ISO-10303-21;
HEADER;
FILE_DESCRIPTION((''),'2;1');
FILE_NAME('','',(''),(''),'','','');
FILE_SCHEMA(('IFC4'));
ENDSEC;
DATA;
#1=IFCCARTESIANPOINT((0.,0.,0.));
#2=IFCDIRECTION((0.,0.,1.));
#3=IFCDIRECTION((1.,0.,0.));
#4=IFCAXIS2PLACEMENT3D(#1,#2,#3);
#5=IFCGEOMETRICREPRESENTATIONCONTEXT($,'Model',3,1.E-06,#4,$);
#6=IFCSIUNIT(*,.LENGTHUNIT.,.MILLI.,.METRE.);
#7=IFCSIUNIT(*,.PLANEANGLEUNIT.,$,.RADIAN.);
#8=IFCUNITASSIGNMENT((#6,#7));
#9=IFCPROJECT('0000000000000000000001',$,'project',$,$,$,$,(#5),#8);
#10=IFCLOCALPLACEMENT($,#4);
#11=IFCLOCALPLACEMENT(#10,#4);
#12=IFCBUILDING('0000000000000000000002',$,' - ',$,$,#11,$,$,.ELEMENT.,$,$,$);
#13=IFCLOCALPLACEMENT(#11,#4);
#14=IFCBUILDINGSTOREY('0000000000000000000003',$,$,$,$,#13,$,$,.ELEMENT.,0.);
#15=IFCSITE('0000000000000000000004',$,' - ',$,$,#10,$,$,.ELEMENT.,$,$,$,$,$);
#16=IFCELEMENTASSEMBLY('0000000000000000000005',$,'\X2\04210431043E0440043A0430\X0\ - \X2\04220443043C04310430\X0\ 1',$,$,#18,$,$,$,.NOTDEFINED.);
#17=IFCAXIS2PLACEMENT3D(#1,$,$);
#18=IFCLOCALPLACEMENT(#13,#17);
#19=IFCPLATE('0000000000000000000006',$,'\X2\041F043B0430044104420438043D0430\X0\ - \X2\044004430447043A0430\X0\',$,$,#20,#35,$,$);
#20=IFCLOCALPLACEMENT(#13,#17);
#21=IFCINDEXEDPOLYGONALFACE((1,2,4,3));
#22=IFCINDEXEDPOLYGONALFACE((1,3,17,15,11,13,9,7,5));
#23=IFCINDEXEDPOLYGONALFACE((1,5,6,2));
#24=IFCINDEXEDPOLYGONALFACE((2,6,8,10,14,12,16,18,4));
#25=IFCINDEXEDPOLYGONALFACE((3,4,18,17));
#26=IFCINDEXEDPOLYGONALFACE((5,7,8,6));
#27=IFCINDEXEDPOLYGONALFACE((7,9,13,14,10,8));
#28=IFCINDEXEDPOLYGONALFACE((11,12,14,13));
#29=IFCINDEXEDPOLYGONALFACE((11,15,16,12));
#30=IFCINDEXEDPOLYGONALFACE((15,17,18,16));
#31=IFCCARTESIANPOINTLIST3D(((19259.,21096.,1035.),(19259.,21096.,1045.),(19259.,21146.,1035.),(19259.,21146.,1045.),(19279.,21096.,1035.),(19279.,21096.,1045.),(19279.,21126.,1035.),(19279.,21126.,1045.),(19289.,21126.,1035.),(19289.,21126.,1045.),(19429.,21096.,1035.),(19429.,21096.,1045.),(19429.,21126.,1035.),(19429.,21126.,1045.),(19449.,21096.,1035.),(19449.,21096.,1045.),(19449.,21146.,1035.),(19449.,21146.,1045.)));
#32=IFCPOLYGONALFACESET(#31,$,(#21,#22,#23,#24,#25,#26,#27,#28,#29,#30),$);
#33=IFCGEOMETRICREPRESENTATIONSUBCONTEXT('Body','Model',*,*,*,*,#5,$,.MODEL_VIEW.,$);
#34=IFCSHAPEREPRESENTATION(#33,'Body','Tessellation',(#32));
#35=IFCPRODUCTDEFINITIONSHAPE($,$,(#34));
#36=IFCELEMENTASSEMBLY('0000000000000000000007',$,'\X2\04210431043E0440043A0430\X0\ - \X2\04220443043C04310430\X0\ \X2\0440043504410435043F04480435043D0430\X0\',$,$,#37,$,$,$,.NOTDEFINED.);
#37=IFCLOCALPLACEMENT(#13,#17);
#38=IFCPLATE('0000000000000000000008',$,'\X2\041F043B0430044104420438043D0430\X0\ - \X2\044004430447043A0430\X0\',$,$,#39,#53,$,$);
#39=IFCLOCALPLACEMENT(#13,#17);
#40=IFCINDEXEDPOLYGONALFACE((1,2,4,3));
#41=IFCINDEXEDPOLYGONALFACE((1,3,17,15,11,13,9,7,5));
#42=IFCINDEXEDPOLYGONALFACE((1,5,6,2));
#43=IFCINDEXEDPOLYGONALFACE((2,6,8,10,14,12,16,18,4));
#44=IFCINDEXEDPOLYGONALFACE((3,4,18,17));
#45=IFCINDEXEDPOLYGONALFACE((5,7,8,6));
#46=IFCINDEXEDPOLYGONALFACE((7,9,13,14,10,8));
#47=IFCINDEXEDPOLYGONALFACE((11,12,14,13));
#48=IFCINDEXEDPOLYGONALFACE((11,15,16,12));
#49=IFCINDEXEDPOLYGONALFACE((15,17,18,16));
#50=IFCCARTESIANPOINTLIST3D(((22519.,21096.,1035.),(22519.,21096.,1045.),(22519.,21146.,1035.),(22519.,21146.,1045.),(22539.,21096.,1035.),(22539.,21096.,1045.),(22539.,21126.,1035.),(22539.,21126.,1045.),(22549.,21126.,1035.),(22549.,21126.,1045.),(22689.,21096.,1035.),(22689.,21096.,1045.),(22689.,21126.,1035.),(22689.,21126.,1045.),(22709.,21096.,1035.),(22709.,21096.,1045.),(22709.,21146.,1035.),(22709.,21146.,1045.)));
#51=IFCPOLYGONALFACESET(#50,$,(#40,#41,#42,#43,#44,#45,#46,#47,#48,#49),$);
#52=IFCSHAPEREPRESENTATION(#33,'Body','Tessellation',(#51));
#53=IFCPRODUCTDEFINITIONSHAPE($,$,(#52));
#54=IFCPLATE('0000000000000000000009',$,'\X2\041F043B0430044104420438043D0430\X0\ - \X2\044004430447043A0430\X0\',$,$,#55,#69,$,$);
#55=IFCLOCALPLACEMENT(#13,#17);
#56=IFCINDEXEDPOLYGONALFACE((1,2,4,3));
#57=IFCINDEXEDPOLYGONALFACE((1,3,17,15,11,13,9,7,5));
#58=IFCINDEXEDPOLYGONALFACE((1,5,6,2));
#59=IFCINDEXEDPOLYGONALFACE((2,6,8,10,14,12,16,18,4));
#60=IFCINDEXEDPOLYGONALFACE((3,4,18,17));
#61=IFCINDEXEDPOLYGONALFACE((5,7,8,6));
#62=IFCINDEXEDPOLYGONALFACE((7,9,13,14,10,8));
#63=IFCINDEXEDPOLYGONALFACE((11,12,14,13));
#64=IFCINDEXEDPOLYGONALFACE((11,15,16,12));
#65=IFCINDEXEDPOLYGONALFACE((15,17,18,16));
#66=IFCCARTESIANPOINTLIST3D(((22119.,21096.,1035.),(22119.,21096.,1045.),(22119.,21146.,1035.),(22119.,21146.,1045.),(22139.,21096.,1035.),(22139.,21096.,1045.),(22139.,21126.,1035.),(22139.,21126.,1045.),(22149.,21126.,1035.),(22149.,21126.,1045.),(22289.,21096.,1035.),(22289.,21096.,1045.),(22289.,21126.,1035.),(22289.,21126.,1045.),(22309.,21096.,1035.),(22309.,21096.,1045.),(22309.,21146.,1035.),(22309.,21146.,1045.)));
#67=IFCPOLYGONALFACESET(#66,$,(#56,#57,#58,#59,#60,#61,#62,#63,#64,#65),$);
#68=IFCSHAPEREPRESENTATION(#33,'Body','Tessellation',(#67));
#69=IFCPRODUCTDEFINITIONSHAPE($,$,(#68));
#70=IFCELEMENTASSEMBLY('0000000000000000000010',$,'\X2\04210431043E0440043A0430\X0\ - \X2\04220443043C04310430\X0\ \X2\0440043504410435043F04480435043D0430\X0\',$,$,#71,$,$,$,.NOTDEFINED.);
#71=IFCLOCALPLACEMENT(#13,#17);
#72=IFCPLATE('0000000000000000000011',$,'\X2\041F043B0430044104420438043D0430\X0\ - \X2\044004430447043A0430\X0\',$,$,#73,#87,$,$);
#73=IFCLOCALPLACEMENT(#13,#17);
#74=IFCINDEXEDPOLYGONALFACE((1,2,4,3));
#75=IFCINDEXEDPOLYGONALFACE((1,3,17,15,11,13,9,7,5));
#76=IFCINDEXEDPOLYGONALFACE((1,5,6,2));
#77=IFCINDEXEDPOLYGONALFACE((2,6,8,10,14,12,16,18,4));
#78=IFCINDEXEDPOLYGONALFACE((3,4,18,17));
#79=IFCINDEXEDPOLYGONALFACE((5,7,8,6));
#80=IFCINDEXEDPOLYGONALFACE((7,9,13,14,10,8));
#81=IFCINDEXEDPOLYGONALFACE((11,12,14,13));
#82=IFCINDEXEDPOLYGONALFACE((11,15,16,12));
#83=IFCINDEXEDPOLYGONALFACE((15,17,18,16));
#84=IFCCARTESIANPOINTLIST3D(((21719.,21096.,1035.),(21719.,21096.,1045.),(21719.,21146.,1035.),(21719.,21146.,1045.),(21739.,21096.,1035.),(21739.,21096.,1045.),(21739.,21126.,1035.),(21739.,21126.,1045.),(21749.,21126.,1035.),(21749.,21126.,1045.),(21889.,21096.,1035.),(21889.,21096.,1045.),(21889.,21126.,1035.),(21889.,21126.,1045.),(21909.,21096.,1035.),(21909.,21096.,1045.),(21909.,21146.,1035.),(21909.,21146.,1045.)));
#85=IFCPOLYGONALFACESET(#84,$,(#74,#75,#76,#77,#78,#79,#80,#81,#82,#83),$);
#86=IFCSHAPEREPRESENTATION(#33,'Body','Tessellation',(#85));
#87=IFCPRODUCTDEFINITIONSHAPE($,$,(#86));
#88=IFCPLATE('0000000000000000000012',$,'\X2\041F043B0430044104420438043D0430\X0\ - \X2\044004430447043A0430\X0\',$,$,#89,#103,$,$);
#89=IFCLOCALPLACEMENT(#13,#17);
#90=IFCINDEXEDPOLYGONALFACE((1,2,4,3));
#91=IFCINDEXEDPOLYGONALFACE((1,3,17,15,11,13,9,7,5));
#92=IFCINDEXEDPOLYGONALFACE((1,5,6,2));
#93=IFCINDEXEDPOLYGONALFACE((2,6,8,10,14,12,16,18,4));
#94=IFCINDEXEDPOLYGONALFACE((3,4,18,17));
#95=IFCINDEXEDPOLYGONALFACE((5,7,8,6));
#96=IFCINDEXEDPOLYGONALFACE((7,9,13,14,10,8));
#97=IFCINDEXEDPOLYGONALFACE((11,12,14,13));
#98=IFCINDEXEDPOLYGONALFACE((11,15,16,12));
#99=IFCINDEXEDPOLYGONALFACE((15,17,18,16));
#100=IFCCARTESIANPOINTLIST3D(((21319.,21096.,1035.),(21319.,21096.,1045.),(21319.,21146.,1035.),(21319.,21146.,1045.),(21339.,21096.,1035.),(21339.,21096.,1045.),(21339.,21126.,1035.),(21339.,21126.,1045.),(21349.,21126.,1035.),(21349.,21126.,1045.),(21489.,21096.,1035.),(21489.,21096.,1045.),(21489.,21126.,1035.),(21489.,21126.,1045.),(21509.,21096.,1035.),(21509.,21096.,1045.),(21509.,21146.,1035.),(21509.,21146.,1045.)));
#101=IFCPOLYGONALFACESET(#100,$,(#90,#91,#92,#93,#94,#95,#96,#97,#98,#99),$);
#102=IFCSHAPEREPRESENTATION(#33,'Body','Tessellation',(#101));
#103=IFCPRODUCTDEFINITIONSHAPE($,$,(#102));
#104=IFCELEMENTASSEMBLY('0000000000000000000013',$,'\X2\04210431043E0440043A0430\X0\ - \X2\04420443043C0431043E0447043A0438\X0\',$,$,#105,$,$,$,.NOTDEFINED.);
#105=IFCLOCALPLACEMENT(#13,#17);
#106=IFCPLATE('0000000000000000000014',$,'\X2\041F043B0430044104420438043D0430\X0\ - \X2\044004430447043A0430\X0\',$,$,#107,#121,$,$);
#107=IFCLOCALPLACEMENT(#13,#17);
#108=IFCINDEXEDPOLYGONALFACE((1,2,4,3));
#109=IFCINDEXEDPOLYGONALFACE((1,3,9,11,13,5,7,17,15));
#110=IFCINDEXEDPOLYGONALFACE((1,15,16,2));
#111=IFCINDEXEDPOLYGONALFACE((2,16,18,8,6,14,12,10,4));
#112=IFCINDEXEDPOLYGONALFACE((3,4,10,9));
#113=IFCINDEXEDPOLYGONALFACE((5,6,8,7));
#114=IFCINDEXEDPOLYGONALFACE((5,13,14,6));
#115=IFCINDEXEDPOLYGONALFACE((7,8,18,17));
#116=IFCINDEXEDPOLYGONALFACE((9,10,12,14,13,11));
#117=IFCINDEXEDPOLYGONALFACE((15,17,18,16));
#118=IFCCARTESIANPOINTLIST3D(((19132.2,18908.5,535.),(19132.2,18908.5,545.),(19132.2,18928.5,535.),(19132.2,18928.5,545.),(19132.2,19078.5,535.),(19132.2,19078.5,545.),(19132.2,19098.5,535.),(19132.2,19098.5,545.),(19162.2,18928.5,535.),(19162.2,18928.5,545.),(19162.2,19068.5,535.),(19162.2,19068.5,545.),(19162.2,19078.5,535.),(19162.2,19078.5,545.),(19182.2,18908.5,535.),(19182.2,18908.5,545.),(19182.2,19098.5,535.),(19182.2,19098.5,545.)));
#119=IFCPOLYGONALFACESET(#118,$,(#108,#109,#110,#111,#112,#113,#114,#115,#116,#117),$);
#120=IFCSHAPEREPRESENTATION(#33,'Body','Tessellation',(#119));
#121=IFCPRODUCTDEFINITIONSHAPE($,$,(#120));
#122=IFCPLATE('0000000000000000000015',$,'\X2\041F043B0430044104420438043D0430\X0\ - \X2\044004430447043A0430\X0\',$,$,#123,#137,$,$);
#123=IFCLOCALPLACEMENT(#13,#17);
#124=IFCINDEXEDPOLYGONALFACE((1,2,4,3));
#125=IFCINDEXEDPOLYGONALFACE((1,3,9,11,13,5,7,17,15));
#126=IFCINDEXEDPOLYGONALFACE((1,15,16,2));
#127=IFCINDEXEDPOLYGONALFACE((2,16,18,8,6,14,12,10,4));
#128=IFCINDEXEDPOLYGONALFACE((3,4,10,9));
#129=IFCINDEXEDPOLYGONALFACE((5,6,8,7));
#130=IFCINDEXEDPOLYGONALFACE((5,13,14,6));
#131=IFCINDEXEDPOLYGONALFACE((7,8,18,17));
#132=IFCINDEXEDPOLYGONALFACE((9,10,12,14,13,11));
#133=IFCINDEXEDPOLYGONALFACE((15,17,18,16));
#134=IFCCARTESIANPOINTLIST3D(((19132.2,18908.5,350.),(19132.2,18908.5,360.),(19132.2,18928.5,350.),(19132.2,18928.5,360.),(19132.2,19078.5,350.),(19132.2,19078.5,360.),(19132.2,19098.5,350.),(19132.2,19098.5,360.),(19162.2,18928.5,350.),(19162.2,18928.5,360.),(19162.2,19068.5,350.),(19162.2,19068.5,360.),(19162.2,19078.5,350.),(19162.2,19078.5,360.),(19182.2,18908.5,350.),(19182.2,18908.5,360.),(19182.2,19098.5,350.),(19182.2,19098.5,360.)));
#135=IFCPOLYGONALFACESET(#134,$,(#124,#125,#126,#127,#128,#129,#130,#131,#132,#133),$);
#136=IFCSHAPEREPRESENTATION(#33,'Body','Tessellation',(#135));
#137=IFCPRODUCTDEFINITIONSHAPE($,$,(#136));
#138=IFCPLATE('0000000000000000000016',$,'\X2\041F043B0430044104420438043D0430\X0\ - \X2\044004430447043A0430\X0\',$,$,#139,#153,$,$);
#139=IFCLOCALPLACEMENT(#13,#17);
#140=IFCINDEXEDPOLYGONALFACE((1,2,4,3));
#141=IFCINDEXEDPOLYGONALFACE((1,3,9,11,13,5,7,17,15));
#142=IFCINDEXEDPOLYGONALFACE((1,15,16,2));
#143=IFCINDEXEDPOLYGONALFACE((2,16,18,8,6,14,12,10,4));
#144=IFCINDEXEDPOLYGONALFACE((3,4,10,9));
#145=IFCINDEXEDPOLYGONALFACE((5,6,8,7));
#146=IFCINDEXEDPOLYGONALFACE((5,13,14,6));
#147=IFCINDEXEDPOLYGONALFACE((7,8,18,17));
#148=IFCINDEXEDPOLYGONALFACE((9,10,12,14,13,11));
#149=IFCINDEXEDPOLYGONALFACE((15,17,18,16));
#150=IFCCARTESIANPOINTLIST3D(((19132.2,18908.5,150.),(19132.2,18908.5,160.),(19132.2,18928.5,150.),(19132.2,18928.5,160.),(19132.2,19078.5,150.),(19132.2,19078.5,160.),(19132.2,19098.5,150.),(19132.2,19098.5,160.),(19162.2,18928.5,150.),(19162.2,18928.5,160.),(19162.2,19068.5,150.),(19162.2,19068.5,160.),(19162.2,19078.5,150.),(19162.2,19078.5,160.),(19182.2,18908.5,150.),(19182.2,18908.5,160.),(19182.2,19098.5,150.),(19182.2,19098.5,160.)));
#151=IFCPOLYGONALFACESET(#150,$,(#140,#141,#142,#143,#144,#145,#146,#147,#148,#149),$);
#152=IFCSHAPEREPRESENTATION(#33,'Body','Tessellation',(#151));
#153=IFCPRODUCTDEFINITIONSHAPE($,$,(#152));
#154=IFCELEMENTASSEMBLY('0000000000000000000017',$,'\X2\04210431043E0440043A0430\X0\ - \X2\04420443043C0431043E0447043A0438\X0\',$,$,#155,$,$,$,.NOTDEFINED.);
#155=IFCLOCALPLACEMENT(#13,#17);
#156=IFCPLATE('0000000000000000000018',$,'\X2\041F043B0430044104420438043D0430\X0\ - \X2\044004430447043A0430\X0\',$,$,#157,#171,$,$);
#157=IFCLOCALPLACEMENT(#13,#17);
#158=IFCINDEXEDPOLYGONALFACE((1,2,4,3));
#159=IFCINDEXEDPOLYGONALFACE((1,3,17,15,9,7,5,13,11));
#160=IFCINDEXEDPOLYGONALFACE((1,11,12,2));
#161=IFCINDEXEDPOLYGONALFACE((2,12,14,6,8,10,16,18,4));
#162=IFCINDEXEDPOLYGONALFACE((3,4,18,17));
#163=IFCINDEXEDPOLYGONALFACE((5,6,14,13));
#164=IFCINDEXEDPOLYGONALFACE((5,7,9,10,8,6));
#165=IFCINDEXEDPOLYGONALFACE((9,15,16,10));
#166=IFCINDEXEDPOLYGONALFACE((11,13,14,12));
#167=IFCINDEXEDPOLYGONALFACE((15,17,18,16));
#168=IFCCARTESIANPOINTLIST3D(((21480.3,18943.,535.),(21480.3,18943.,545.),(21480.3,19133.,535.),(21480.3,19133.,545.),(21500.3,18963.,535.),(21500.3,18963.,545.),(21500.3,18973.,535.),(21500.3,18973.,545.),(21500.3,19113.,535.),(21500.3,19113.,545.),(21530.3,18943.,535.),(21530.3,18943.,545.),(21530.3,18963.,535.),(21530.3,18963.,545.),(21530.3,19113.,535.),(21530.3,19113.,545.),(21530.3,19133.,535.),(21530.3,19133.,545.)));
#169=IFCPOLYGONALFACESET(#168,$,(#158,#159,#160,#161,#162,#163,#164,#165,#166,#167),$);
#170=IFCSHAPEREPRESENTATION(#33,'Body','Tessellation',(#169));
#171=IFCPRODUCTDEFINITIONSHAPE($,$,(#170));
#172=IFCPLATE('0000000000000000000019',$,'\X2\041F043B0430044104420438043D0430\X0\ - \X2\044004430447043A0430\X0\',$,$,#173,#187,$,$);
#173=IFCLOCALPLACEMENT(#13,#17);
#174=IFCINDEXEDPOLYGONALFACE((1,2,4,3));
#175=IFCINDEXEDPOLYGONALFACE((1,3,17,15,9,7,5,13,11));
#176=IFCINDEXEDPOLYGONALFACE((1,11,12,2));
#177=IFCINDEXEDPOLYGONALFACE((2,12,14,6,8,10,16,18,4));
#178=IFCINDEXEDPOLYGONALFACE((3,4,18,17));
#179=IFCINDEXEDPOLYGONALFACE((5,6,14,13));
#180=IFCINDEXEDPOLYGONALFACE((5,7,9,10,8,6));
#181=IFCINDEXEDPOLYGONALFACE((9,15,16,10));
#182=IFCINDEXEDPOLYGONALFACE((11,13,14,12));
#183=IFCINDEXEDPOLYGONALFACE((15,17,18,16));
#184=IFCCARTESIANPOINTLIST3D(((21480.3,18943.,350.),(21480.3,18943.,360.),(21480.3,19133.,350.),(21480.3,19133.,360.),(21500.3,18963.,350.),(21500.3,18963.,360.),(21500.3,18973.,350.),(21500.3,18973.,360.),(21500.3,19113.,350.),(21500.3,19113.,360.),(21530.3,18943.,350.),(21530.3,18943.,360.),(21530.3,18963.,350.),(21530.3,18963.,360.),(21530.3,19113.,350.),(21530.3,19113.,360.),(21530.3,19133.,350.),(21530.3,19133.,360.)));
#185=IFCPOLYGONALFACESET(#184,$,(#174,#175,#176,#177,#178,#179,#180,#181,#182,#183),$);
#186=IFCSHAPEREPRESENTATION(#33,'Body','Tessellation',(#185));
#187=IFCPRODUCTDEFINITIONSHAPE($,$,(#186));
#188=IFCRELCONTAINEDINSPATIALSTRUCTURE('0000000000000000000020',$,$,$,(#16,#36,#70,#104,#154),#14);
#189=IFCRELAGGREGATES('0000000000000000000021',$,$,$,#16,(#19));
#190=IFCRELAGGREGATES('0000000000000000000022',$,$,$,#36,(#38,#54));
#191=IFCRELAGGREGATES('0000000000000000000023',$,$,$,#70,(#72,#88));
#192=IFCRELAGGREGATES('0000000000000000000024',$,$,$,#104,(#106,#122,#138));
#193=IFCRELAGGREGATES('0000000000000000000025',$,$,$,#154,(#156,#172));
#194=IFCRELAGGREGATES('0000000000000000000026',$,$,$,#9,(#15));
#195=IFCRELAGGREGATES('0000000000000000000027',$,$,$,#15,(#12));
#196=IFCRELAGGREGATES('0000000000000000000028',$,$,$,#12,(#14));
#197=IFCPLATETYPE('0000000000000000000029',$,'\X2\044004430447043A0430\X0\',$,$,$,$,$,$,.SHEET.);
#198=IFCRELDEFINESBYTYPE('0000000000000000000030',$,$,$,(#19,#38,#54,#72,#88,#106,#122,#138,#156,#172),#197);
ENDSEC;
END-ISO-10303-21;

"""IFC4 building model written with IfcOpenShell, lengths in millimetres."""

from ifc_helpers import new_model, si_unit, frame, origin_with_axes, place, context, subcontext, project, spatial, line, indexed_curve, outline, extrude, source, transform, mapped, type_object, element, aggregate, save


model = new_model("IFC4")

# Units and contexts
model_context = context("Model", 3, precision=1e-06, world=origin_with_axes())
body_context = subcontext(model_context, "Body", "Model", "MODEL_VIEW")
ifc_project = project(units=[si_unit("LENGTHUNIT", "METRE", prefix="MILLI"), si_unit("PLANEANGLEUNIT", "RADIAN")], contexts=[model_context])

# Site, building, storey
site_placement = place(None, origin_with_axes())
site = spatial("IfcSite", under=ifc_project, at=site_placement, Name=" - ", CompositionType="ELEMENT")
building_placement = place(site_placement, origin_with_axes())
building = spatial("IfcBuilding", under=site, at=building_placement, Name=" - ", CompositionType="ELEMENT")
storey_placement = place(building_placement, origin_with_axes())
storey = spatial("IfcBuildingStorey", under=building, at=storey_placement, CompositionType="ELEMENT", Elevation=0.0)

# Element assembly, plate
assembly_1_placement = place(storey_placement, frame((19554.0, 21081.0, 0.0), z_axis=(0.0, 0.0, 1.0), x_axis=(-1.0, 0.0, 0.0)))
assembly_1 = element("IfcElementAssembly", 1, at=assembly_1_placement, inside=storey, Name="Сборка - Тумба 1", PredefinedType="NOTDEFINED")
plate_type = type_object("IfcPlateType", Name="ручка", PredefinedType="SHEET")
shared_shape = source(origin_with_axes(), body_context, "Body", "SweptSolid", [
    extrude(outline(indexed_curve([(-95.0, -25.0), (-75.0, -25.0), (-75.0, 5.0), (-65.0, 5.0), (75.0, 5.0), (75.0, -25.0), (95.0, -25.0), (95.0, 25.0), (-95.0, 25.0)], segments=[line(1, 2), line(2, 3), line(3, 4), line(4, 5), line(5, 6), line(6, 7), line(7, 8), line(8, 9), line(9, 1)])), origin_with_axes(), (0.0, 0.0, 1.0), 10.0),
])
plate_1_placement = place(assembly_1_placement, frame((200.0, -40.0, 1035.0), z_axis=(0.0, 0.0, 1.0), x_axis=(-1.0, 0.0, 0.0)))
plate_1 = element("IfcPlate", 2, at=plate_1_placement, type_object=plate_type, Name="Пластина - ручка", context=body_context, shape_type="MappedRepresentation", body=[
    mapped(shared_shape, transform((0.0, 0.0, 0.0), x_axis=(1.0, 0.0, 0.0), y_axis=(0.0, 1.0, 0.0), z_axis=(0.0, 0.0, 1.0), scale=1.0)),
])
aggregate(assembly_1, [plate_1])

# Element assemblies, plates
assembly_2_placement = place(storey_placement, frame((22814.0, 21081.0, 0.0), z_axis=(0.0, 0.0, 1.0), x_axis=(-1.0, 0.0, 0.0)))
assembly_2 = element("IfcElementAssembly", 3, at=assembly_2_placement, inside=storey, Name="Сборка - Тумба ресепшена", PredefinedType="NOTDEFINED")
plate_2_placement = place(assembly_2_placement, frame((200.0, -40.0, 1035.0), z_axis=(0.0, 0.0, 1.0), x_axis=(-1.0, 0.0, 0.0)))
plate_2 = element("IfcPlate", 4, at=plate_2_placement, type_object=plate_type, Name="Пластина - ручка", context=body_context, shape_type="MappedRepresentation", body=[
    mapped(shared_shape, transform((0.0, 0.0, 0.0), x_axis=(1.0, 0.0, 0.0), y_axis=(0.0, 1.0, 0.0), z_axis=(0.0, 0.0, 1.0), scale=1.0)),
])
plate_3_placement = place(assembly_2_placement, frame((600.0, -40.0, 1035.0), z_axis=(0.0, 0.0, 1.0), x_axis=(-1.0, 0.0, 0.0)))
plate_3 = element("IfcPlate", 5, at=plate_3_placement, type_object=plate_type, Name="Пластина - ручка", context=body_context, shape_type="MappedRepresentation", body=[
    mapped(shared_shape, transform((0.0, 0.0, 0.0), x_axis=(1.0, 0.0, 0.0), y_axis=(0.0, 1.0, 0.0), z_axis=(0.0, 0.0, 1.0), scale=1.0)),
])
aggregate(assembly_2, [plate_2, plate_3])
assembly_3_placement = place(storey_placement, frame((22014.0, 21081.0, 0.0), z_axis=(0.0, 0.0, 1.0), x_axis=(-1.0, 0.0, 0.0)))
assembly_3 = element("IfcElementAssembly", 6, at=assembly_3_placement, inside=storey, Name="Сборка - Тумба ресепшена", PredefinedType="NOTDEFINED")
plate_4_placement = place(assembly_3_placement, frame((200.0, -40.0, 1035.0), z_axis=(0.0, 0.0, 1.0), x_axis=(-1.0, 0.0, 0.0)))
plate_4 = element("IfcPlate", 7, at=plate_4_placement, type_object=plate_type, Name="Пластина - ручка", context=body_context, shape_type="MappedRepresentation", body=[
    mapped(shared_shape, transform((0.0, 0.0, 0.0), x_axis=(1.0, 0.0, 0.0), y_axis=(0.0, 1.0, 0.0), z_axis=(0.0, 0.0, 1.0), scale=1.0)),
])
plate_5_placement = place(assembly_3_placement, frame((600.0, -40.0, 1035.0), z_axis=(0.0, 0.0, 1.0), x_axis=(-1.0, 0.0, 0.0)))
plate_5 = element("IfcPlate", 8, at=plate_5_placement, type_object=plate_type, Name="Пластина - ручка", context=body_context, shape_type="MappedRepresentation", body=[
    mapped(shared_shape, transform((0.0, 0.0, 0.0), x_axis=(1.0, 0.0, 0.0), y_axis=(0.0, 1.0, 0.0), z_axis=(0.0, 0.0, 1.0), scale=1.0)),
])
aggregate(assembly_3, [plate_4, plate_5])
assembly_4_placement = place(storey_placement, frame((19132.2, 18803.5, 0.0), z_axis=(0.0, 0.0, 1.0), x_axis=(0.0, 1.0, 0.0)))
assembly_4 = element("IfcElementAssembly", 9, at=assembly_4_placement, inside=storey, Name="Сборка - тумбочки", PredefinedType="NOTDEFINED")
plate_6_placement = place(assembly_4_placement, frame((200.0, -25.0, 535.0), z_axis=(0.0, 0.0, 1.0), x_axis=(-1.0, 0.0, 0.0)))
plate_6 = element("IfcPlate", 10, at=plate_6_placement, type_object=plate_type, Name="Пластина - ручка", context=body_context, shape_type="MappedRepresentation", body=[
    mapped(shared_shape, transform((0.0, 0.0, 0.0), x_axis=(1.0, 0.0, 0.0), y_axis=(0.0, 1.0, 0.0), z_axis=(0.0, 0.0, 1.0), scale=1.0)),
])
plate_7_placement = place(assembly_4_placement, frame((200.0, -25.0, 350.0), z_axis=(0.0, 0.0, 1.0), x_axis=(-1.0, 0.0, 0.0)))
plate_7 = element("IfcPlate", 11, at=plate_7_placement, type_object=plate_type, Name="Пластина - ручка", context=body_context, shape_type="MappedRepresentation", body=[
    mapped(shared_shape, transform((0.0, 0.0, 0.0), x_axis=(1.0, 0.0, 0.0), y_axis=(0.0, 1.0, 0.0), z_axis=(0.0, 0.0, 1.0), scale=1.0)),
])
plate_8_placement = place(assembly_4_placement, frame((200.0, -25.0, 150.0), z_axis=(0.0, 0.0, 1.0), x_axis=(-1.0, 0.0, 0.0)))
plate_8 = element("IfcPlate", 12, at=plate_8_placement, type_object=plate_type, Name="Пластина - ручка", context=body_context, shape_type="MappedRepresentation", body=[
    mapped(shared_shape, transform((0.0, 0.0, 0.0), x_axis=(1.0, 0.0, 0.0), y_axis=(0.0, 1.0, 0.0), z_axis=(0.0, 0.0, 1.0), scale=1.0)),
])
aggregate(assembly_4, [plate_6, plate_7, plate_8])
assembly_5_placement = place(storey_placement, frame((21530.3, 19238.0, 0.0), z_axis=(0.0, 0.0, 1.0), x_axis=(0.0, -1.0, 0.0)))
assembly_5 = element("IfcElementAssembly", 13, at=assembly_5_placement, inside=storey, Name="Сборка - тумбочки", PredefinedType="NOTDEFINED")
plate_9_placement = place(assembly_5_placement, frame((200.0, -25.0, 535.0), z_axis=(0.0, 0.0, 1.0), x_axis=(-1.0, 0.0, 0.0)))
plate_9 = element("IfcPlate", 14, at=plate_9_placement, type_object=plate_type, Name="Пластина - ручка", context=body_context, shape_type="MappedRepresentation", body=[
    mapped(shared_shape, transform((0.0, 0.0, 0.0), x_axis=(1.0, 0.0, 0.0), y_axis=(0.0, 1.0, 0.0), z_axis=(0.0, 0.0, 1.0), scale=1.0)),
])
plate_10_placement = place(assembly_5_placement, frame((200.0, -25.0, 350.0), z_axis=(0.0, 0.0, 1.0), x_axis=(-1.0, 0.0, 0.0)))
plate_10 = element("IfcPlate", 15, at=plate_10_placement, type_object=plate_type, Name="Пластина - ручка", context=body_context, shape_type="MappedRepresentation", body=[
    mapped(shared_shape, transform((0.0, 0.0, 0.0), x_axis=(1.0, 0.0, 0.0), y_axis=(0.0, 1.0, 0.0), z_axis=(0.0, 0.0, 1.0), scale=1.0)),
])
aggregate(assembly_5, [plate_9, plate_10])

save(model, "model.ifc")
